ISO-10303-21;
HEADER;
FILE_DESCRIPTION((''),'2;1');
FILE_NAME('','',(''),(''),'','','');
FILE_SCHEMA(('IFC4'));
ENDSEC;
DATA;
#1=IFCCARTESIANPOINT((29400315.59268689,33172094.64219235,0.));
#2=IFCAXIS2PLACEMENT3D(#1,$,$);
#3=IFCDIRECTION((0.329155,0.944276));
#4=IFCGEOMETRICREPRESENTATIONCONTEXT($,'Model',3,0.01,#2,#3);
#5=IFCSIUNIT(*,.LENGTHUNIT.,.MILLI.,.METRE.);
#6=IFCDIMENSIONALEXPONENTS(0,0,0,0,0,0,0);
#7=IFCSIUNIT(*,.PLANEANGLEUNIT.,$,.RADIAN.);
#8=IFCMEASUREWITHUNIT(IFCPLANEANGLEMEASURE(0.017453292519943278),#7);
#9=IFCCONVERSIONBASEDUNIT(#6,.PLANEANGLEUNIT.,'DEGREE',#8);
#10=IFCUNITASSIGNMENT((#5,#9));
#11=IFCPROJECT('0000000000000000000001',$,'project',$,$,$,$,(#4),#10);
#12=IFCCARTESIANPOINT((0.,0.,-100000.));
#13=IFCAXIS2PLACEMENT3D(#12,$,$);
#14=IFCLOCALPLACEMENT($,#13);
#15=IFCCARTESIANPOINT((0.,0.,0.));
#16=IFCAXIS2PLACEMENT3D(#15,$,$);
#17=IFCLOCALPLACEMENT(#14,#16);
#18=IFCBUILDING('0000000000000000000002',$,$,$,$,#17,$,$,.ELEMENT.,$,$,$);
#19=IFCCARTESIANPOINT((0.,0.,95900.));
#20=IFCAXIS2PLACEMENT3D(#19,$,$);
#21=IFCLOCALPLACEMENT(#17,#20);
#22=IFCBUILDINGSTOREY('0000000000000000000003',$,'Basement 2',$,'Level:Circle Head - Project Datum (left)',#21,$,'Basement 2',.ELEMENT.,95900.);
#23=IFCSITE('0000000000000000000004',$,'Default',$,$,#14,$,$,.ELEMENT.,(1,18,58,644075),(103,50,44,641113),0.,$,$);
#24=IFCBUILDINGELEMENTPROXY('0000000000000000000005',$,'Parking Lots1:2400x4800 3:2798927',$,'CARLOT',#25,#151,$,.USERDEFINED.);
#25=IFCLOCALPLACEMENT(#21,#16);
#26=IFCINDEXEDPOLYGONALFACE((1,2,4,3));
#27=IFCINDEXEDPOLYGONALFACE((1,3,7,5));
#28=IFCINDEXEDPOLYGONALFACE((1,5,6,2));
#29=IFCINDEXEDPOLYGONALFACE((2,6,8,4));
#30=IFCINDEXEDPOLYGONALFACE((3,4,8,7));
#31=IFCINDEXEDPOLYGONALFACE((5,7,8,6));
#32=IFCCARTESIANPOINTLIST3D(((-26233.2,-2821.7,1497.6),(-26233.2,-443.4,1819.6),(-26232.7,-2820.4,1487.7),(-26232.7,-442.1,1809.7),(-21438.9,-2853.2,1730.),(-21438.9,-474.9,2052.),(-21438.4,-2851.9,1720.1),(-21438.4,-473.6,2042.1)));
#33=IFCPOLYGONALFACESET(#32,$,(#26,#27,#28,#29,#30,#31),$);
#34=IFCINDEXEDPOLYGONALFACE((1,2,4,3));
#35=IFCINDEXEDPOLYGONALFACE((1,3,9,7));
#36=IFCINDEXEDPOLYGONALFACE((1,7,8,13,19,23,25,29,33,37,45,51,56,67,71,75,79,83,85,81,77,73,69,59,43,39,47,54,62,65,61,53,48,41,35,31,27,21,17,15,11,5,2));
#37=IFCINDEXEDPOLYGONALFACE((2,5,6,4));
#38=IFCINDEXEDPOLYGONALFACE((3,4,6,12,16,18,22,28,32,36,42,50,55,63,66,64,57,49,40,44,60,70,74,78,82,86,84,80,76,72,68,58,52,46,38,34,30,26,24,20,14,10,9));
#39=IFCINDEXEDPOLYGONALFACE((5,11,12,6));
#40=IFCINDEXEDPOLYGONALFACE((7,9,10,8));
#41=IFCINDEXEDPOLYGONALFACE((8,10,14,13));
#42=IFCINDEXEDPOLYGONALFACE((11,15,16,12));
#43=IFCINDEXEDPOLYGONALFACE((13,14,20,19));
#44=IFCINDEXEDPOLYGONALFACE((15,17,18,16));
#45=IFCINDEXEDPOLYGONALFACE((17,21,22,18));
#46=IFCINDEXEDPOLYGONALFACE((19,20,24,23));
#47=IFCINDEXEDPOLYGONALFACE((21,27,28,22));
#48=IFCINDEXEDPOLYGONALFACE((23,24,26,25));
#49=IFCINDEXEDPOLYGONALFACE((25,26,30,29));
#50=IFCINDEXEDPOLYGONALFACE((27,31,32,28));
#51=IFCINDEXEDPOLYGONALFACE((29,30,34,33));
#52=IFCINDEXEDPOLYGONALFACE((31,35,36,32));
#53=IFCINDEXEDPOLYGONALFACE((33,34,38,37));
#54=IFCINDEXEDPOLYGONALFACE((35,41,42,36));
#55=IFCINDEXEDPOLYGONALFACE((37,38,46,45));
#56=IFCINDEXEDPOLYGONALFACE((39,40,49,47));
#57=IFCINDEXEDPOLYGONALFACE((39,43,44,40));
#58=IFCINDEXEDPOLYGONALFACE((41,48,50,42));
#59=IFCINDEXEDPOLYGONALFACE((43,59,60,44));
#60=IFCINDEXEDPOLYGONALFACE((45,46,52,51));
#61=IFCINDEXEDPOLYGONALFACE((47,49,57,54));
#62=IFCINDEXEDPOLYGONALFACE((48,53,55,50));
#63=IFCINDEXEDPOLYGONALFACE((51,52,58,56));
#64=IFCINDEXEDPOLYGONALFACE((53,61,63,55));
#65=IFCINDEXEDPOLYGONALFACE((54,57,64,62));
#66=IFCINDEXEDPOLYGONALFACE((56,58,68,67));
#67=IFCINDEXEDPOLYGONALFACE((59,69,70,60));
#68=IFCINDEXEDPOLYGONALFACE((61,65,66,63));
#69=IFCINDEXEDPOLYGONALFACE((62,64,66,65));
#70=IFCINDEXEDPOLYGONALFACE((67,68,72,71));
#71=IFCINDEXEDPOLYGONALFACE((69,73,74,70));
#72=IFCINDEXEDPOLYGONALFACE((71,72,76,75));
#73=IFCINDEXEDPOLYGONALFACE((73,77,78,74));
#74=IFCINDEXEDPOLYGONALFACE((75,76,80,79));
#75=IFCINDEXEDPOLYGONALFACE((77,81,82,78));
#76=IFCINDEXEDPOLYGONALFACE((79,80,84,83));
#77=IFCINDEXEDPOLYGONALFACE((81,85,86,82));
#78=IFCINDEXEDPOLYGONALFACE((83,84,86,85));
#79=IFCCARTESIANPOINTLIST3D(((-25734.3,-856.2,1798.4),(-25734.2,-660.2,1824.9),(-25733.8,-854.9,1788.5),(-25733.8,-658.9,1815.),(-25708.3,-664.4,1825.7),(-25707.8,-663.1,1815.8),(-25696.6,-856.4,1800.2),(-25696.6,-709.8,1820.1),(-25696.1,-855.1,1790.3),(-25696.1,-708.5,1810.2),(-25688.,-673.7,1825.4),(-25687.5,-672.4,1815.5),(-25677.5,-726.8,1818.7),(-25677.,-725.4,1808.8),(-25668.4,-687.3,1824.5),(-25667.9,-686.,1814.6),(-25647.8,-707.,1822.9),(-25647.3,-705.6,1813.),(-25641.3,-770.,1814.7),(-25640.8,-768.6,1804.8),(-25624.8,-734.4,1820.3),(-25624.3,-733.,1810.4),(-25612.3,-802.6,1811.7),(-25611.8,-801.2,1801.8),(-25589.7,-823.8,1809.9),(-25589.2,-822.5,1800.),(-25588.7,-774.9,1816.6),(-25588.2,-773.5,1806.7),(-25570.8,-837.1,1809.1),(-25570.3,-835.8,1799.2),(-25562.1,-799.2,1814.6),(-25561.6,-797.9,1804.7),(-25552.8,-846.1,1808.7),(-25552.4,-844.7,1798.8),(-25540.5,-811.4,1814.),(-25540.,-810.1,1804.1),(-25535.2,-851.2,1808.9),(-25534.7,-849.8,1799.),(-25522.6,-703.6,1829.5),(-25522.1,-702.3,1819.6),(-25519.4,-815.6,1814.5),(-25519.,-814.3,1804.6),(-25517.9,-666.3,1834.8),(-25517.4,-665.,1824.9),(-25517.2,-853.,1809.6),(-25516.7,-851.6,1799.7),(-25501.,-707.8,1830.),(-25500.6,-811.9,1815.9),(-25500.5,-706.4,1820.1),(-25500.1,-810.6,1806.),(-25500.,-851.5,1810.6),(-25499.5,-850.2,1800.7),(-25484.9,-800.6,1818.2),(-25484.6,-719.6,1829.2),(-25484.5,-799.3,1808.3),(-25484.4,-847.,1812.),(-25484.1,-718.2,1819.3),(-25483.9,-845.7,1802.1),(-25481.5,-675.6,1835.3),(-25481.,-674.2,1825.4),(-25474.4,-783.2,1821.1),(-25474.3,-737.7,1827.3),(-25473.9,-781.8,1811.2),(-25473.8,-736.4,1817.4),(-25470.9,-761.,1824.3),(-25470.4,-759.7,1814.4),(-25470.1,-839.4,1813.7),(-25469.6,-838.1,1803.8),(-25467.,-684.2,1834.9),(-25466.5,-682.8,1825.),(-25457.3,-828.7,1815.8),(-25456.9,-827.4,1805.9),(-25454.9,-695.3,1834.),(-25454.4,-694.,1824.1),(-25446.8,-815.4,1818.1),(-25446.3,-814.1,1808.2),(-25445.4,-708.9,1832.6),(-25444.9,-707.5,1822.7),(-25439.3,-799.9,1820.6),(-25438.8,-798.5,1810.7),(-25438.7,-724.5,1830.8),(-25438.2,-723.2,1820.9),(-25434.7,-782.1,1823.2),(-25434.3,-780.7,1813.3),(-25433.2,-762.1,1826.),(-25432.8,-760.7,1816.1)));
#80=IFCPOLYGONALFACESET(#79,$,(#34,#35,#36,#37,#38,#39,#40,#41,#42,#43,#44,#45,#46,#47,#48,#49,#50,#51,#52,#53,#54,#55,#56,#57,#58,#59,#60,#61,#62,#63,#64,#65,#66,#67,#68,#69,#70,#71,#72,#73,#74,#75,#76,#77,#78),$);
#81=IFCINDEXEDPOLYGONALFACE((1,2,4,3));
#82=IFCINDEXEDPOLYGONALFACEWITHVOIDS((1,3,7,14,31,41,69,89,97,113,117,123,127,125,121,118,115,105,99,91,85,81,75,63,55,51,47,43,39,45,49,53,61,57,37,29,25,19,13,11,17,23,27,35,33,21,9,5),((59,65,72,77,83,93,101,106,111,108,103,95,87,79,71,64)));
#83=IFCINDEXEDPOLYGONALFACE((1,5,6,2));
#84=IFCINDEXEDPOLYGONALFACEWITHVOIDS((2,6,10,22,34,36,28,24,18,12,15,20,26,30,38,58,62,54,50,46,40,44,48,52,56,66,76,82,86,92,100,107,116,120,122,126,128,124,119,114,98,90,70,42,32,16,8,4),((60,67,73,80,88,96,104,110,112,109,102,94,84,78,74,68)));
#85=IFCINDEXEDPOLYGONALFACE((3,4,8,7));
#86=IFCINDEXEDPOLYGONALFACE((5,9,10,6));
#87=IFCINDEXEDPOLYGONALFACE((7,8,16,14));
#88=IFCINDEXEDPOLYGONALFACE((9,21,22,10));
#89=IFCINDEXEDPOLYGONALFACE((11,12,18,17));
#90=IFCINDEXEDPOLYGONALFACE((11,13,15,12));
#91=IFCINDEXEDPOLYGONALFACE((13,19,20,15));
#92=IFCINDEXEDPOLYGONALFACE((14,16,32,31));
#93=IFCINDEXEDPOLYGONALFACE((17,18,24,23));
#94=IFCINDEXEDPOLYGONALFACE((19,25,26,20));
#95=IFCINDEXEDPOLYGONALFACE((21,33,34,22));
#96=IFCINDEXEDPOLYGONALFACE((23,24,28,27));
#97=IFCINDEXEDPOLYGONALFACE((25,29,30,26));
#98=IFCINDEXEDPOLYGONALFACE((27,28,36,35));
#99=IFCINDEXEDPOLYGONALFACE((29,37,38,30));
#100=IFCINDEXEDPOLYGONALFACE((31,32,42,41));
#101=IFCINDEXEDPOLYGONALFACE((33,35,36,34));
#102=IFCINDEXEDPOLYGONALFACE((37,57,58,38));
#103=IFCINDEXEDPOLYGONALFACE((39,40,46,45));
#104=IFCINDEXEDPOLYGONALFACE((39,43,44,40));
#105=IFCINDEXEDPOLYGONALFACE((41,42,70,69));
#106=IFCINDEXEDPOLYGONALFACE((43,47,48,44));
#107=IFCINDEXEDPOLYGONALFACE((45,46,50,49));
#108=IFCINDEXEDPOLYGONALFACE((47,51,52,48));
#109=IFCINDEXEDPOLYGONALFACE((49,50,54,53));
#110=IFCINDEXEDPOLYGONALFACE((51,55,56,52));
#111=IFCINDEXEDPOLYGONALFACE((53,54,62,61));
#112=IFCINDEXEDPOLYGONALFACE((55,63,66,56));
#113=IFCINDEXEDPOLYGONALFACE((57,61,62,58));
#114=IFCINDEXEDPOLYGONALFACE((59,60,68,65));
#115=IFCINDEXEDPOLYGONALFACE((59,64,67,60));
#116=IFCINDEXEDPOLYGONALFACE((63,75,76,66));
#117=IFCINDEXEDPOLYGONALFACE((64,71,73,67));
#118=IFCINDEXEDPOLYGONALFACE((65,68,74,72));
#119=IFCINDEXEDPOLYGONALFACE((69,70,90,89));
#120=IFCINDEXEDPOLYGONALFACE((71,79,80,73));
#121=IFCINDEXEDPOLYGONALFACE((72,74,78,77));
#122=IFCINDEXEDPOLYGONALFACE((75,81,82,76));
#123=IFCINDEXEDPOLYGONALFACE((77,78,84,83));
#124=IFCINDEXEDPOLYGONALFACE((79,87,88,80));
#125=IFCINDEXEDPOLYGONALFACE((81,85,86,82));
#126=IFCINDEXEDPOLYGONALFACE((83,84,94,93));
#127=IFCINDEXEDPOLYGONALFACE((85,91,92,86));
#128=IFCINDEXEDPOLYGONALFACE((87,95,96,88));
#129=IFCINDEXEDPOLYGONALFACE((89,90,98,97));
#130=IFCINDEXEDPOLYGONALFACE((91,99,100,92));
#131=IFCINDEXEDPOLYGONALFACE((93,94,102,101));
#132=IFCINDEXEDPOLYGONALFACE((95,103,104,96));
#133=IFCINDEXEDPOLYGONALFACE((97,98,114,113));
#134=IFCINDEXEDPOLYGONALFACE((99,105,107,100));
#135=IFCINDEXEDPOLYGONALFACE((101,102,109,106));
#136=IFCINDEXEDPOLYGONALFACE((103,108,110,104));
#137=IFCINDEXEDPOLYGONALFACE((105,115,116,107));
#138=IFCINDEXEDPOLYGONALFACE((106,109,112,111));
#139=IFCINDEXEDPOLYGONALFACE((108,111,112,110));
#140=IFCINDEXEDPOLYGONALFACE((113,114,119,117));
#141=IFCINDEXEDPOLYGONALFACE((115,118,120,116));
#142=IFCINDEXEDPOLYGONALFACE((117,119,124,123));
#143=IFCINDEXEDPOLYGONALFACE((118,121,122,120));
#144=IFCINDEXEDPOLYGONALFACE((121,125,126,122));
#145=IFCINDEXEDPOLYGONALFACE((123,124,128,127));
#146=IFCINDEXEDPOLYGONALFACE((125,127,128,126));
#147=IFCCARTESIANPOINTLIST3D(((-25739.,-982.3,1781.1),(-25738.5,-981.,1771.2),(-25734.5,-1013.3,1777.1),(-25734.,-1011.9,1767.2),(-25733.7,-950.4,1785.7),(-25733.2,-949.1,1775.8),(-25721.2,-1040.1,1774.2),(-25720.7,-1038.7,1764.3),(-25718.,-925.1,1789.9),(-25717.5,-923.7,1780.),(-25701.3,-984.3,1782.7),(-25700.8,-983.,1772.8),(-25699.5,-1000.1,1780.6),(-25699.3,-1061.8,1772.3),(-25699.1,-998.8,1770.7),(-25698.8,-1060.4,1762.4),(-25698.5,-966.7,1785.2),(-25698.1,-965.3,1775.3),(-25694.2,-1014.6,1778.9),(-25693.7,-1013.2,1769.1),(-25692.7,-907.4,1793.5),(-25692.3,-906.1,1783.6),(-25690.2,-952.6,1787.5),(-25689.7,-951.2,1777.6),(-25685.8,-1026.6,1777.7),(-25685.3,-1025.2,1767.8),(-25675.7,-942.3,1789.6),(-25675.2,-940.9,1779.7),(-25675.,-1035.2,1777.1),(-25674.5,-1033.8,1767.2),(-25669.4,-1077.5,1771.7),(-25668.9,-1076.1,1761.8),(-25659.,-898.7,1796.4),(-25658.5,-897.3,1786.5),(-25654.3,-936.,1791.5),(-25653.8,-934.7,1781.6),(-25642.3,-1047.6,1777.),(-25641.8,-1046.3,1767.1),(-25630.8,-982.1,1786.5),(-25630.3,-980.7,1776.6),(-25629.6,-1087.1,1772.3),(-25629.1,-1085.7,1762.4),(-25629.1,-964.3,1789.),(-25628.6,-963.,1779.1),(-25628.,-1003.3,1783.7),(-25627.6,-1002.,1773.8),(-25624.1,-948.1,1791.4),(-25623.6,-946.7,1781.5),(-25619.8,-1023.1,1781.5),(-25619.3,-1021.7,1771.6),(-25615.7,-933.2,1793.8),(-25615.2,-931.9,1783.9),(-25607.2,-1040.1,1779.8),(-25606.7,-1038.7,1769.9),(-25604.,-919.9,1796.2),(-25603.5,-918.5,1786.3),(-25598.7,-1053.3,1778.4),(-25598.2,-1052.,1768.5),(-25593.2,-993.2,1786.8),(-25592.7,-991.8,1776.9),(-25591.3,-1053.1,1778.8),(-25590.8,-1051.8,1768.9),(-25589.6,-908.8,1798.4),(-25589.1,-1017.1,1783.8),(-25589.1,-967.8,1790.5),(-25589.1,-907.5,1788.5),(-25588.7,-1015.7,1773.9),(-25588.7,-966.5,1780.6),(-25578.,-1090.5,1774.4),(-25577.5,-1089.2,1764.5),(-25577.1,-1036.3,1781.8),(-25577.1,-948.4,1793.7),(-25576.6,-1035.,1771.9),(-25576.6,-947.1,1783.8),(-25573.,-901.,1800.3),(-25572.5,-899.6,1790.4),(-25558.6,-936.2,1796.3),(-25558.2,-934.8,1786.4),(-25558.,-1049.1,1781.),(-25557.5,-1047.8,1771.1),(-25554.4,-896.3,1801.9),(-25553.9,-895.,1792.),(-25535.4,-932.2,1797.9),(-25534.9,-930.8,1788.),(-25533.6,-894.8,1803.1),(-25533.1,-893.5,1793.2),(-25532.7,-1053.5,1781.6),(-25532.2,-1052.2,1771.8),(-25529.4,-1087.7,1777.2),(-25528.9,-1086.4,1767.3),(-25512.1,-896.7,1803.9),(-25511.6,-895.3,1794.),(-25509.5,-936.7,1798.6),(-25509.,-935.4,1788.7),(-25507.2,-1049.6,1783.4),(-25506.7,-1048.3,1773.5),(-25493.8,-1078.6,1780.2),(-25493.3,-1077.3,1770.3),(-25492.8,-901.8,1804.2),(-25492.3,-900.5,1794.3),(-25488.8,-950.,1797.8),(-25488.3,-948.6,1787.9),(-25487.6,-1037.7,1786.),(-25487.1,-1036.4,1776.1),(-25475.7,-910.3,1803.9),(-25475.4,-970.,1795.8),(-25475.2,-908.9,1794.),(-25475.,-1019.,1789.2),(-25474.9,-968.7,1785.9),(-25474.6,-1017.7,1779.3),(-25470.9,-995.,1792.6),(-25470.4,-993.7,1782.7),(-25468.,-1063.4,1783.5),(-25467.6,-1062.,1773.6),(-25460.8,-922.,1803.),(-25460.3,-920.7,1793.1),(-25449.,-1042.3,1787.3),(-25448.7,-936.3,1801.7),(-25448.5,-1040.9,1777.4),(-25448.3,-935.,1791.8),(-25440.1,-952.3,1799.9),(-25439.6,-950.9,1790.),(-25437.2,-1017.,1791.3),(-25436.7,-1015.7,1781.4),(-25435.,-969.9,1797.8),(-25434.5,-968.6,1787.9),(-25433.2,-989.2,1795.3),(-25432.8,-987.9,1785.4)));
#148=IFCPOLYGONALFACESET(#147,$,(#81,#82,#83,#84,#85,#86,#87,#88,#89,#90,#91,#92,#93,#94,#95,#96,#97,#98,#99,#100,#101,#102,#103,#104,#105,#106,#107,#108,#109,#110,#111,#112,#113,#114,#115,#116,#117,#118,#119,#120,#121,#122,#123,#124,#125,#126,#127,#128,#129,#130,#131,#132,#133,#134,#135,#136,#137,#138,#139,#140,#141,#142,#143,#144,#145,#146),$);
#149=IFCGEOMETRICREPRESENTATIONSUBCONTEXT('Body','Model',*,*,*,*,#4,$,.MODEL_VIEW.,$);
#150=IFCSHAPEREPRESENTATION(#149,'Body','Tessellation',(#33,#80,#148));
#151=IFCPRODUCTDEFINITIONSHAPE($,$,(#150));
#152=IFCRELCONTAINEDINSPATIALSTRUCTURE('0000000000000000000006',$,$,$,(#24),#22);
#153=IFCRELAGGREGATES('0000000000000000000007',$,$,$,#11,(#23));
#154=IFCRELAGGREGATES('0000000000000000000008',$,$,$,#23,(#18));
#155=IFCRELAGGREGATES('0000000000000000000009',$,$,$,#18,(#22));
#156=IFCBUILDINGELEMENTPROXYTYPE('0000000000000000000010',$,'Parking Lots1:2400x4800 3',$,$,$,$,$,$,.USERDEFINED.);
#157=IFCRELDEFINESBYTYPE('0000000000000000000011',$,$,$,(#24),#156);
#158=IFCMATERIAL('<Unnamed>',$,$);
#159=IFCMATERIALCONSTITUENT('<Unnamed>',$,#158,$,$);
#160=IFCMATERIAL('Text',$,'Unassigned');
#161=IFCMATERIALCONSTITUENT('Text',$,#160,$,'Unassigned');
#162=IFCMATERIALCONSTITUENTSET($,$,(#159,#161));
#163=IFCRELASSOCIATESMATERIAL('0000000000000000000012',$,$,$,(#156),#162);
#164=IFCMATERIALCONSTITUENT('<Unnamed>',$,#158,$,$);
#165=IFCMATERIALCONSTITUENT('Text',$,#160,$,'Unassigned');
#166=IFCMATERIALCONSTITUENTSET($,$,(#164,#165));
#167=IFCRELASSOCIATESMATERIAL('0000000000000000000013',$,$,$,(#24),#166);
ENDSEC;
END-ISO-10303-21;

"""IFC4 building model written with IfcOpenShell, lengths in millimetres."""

from ifc_helpers import new_model, entity, si_unit, converted_unit, direction, frame, origin, place, context, subcontext, project, spatial, indexed_curve, outline, extrude, source, transform, mapped, material, constituent, constituent_set, type_object, type_shapes, element, save


model = new_model("IFC4")

# Units and contexts
model_context = context("Model", 3, precision=0.01, world=frame((29400315.59268689, 33172094.64219235, 0.0)), true_north=direction((0.329155, 0.944276)))
body_context = subcontext(model_context, "Body", "Model", "MODEL_VIEW")
ifc_project = project(units=[si_unit("LENGTHUNIT", "METRE", prefix="MILLI"), converted_unit("PLANEANGLEUNIT", "DEGREE", entity("IfcPlaneAngleMeasure", 0.017453292519943278), si_unit("PLANEANGLEUNIT", "RADIAN"), dimensions=[0, 0, 0, 0, 0, 0, 0])], contexts=[model_context])

# Site, building, storey
site_placement = place(None, frame((0.0, 0.0, -100000.0)))
site = spatial("IfcSite", under=ifc_project, at=site_placement, Name="Default", CompositionType="ELEMENT", RefLatitude=(1, 18, 58, 644075), RefLongitude=(103, 50, 44, 641113), RefElevation=0.0)
building_placement = place(site_placement, origin())
building = spatial("IfcBuilding", under=site, at=building_placement, CompositionType="ELEMENT")
storey_placement = place(building_placement, frame((0.0, 0.0, 95900.0)))
storey = spatial("IfcBuildingStorey", under=building, at=storey_placement, Name="Basement 2", ObjectType="Level:Circle Head - Project Datum (left)", LongName="Basement 2", CompositionType="ELEMENT", Elevation=95900.0)

# Shared definitions
ifc_material_1 = material(Name="<Unnamed>")

# Building element proxy
ifc_material_2 = material(Name="Text", Category="Unassigned")
ifc_constituent_1 = constituent(ifc_material_1, Name="<Unnamed>")
ifc_constituent_2 = constituent(ifc_material_2, Name="Text", Category="Unassigned")
ifc_constituent_set_1 = constituent_set(constituents=[ifc_constituent_1, ifc_constituent_2])
ifc_constituent_3 = constituent(ifc_material_1, Name="<Unnamed>")
ifc_constituent_4 = constituent(ifc_material_2, Name="Text", Category="Unassigned")
ifc_constituent_set_2 = constituent_set(constituents=[ifc_constituent_3, ifc_constituent_4])
building_element_proxy_type_1 = type_object("IfcBuildingElementProxyType", Name="Parking Lots1:2400x4800 3", PredefinedType="USERDEFINED", material=ifc_constituent_set_2)
shared_shape_1 = source(origin(), body_context, "Body", "SweptSolid", [
    extrude(outline(indexed_curve([(-1200.0, -2400.0), (1200.0, -2400.0), (1200.0, 2400.0), (-1200.0, 2400.0), (-1200.0, -2400.0)], self_intersect=False)), frame((1200.0, -2400.0, 0.0), z_axis=(0.0, 0.0, 1.0), x_axis=(-1.0, 0.0, 0.0)), (0.0, 0.0, 1.0), 10.0),
    extrude(outline(indexed_curve([(-91.6, -150.5), (-91.6, -188.2), (106.2, -188.2), (102.1, -162.2), (92.9, -141.9), (79.3, -122.2), (59.6, -101.6), (32.1, -78.5), (-8.5, -42.4), (-32.9, -15.8), (-45.1, 5.8), (-49.2, 26.9), (-45.4, 45.8), (-33.9, 61.4), (-16.2, 72.0), (6.2, 75.5), (29.7, 72.1), (48.0, 61.8), (59.7, 45.4), (63.8, 23.7), (101.5, 28.4), (92.4, 64.9), (83.8, 79.4), (72.6, 91.5), (59.0, 101.0), (43.3, 107.8), (5.4, 113.2), (-14.8, 111.7), (-32.8, 107.2), (-48.5, 99.6), (-62.0, 89.1), (-72.9, 76.3), (-80.7, 62.0), (-85.3, 46.3), (-86.9, 29.2), (-85.2, 11.2), (-80.2, -6.5), (-71.3, -24.6), (-57.9, -43.5), (-36.6, -66.1), (-3.9, -95.1), (39.4, -131.3), (56.4, -150.5), (-91.6, -150.5)], self_intersect=False)), frame((320.3, -4111.8, 10.0), z_axis=(0.0, 0.0, -1.0), x_axis=(-1.0, 0.0, 0.0)), (0.0, 0.0, -1.0), 10.0),
    extrude(outline(indexed_curve([(33.6, -97.6), (68.6, -97.6), (97.6, -86.8), (119.5, -66.0), (132.9, -36.3), (136.6, -5.0), (130.7, 24.5), (115.2, 51.2), (90.3, 74.0), (54.2, 93.5), (5.1, 109.8), (-42.7, 119.3), (-79.6, 119.4), (-108.5, 111.1), (-132.5, 95.3), (-150.5, 73.7), (-161.5, 47.5), (-164.9, 28.3), (-164.5, 9.8), (-160.3, -7.9), (-152.3, -24.9), (-141.0, -40.1), (-126.6, -52.7), (-109.3, -62.6), (-88.9, -69.7), (-68.4, -73.6), (-49.1, -73.7), (-31.0, -70.3), (-14.1, -63.1), (0.7, -53.0), (12.7, -40.7), (21.8, -26.1), (28.0, -9.2), (30.9, 12.2), (28.1, 33.5), (20.3, 53.3), (8.3, 70.0), (15.4, 68.3), (56.3, 51.8), (84.7, 31.4), (92.9, 20.3), (97.9, 6.5), (99.3, -9.0), (96.9, -24.9), (89.6, -41.3), (77.9, -53.0), (61.1, -59.3), (38.8, -60.0), (33.6, -97.6)], self_intersect=False), holes=[indexed_curve([(-48.4, 85.2), (-25.1, 74.5), (-9.9, 57.2), (-3.2, 35.4), (-5.6, 11.1), (-16.1, -12.6), (-32.8, -28.5), (-53.9, -35.8), (-77.4, -33.8), (-101.4, -22.9), (-117.9, -4.7), (-125.7, 18.2), (-123.6, 43.7), (-113.3, 66.1), (-96.3, 81.1), (-74.2, 87.8), (-48.4, 85.2)], self_intersect=False)]), frame((539.9, -4167.0, 10.0), z_axis=(0.0, 0.0, 1.0), x_axis=(0.258285, -0.966069, 0.0)), (0.0, 0.0, 1.0), 10.0),
])
type_shapes(building_element_proxy_type_1, [shared_shape_1])
proxy_1_placement = place(storey_placement, frame((-21438.4, -473.6, 2042.1), z_axis=(-0.048866, -0.133991, 0.989777), x_axis=(-0.000014, -0.990961, -0.134152)))
element("IfcBuildingElementProxy", 1, at=proxy_1_placement, inside=storey, type_object=building_element_proxy_type_1, material=ifc_constituent_set_1, Name="Parking Lots1:2400x4800 3:2798927", ObjectType="CARLOT", PredefinedType="USERDEFINED", context=body_context, shape_type="MappedRepresentation", body=[
    mapped(shared_shape_1, transform((0.0, 0.0, 0.0), scale=1.0)),
])

save(model, "model.ifc")
